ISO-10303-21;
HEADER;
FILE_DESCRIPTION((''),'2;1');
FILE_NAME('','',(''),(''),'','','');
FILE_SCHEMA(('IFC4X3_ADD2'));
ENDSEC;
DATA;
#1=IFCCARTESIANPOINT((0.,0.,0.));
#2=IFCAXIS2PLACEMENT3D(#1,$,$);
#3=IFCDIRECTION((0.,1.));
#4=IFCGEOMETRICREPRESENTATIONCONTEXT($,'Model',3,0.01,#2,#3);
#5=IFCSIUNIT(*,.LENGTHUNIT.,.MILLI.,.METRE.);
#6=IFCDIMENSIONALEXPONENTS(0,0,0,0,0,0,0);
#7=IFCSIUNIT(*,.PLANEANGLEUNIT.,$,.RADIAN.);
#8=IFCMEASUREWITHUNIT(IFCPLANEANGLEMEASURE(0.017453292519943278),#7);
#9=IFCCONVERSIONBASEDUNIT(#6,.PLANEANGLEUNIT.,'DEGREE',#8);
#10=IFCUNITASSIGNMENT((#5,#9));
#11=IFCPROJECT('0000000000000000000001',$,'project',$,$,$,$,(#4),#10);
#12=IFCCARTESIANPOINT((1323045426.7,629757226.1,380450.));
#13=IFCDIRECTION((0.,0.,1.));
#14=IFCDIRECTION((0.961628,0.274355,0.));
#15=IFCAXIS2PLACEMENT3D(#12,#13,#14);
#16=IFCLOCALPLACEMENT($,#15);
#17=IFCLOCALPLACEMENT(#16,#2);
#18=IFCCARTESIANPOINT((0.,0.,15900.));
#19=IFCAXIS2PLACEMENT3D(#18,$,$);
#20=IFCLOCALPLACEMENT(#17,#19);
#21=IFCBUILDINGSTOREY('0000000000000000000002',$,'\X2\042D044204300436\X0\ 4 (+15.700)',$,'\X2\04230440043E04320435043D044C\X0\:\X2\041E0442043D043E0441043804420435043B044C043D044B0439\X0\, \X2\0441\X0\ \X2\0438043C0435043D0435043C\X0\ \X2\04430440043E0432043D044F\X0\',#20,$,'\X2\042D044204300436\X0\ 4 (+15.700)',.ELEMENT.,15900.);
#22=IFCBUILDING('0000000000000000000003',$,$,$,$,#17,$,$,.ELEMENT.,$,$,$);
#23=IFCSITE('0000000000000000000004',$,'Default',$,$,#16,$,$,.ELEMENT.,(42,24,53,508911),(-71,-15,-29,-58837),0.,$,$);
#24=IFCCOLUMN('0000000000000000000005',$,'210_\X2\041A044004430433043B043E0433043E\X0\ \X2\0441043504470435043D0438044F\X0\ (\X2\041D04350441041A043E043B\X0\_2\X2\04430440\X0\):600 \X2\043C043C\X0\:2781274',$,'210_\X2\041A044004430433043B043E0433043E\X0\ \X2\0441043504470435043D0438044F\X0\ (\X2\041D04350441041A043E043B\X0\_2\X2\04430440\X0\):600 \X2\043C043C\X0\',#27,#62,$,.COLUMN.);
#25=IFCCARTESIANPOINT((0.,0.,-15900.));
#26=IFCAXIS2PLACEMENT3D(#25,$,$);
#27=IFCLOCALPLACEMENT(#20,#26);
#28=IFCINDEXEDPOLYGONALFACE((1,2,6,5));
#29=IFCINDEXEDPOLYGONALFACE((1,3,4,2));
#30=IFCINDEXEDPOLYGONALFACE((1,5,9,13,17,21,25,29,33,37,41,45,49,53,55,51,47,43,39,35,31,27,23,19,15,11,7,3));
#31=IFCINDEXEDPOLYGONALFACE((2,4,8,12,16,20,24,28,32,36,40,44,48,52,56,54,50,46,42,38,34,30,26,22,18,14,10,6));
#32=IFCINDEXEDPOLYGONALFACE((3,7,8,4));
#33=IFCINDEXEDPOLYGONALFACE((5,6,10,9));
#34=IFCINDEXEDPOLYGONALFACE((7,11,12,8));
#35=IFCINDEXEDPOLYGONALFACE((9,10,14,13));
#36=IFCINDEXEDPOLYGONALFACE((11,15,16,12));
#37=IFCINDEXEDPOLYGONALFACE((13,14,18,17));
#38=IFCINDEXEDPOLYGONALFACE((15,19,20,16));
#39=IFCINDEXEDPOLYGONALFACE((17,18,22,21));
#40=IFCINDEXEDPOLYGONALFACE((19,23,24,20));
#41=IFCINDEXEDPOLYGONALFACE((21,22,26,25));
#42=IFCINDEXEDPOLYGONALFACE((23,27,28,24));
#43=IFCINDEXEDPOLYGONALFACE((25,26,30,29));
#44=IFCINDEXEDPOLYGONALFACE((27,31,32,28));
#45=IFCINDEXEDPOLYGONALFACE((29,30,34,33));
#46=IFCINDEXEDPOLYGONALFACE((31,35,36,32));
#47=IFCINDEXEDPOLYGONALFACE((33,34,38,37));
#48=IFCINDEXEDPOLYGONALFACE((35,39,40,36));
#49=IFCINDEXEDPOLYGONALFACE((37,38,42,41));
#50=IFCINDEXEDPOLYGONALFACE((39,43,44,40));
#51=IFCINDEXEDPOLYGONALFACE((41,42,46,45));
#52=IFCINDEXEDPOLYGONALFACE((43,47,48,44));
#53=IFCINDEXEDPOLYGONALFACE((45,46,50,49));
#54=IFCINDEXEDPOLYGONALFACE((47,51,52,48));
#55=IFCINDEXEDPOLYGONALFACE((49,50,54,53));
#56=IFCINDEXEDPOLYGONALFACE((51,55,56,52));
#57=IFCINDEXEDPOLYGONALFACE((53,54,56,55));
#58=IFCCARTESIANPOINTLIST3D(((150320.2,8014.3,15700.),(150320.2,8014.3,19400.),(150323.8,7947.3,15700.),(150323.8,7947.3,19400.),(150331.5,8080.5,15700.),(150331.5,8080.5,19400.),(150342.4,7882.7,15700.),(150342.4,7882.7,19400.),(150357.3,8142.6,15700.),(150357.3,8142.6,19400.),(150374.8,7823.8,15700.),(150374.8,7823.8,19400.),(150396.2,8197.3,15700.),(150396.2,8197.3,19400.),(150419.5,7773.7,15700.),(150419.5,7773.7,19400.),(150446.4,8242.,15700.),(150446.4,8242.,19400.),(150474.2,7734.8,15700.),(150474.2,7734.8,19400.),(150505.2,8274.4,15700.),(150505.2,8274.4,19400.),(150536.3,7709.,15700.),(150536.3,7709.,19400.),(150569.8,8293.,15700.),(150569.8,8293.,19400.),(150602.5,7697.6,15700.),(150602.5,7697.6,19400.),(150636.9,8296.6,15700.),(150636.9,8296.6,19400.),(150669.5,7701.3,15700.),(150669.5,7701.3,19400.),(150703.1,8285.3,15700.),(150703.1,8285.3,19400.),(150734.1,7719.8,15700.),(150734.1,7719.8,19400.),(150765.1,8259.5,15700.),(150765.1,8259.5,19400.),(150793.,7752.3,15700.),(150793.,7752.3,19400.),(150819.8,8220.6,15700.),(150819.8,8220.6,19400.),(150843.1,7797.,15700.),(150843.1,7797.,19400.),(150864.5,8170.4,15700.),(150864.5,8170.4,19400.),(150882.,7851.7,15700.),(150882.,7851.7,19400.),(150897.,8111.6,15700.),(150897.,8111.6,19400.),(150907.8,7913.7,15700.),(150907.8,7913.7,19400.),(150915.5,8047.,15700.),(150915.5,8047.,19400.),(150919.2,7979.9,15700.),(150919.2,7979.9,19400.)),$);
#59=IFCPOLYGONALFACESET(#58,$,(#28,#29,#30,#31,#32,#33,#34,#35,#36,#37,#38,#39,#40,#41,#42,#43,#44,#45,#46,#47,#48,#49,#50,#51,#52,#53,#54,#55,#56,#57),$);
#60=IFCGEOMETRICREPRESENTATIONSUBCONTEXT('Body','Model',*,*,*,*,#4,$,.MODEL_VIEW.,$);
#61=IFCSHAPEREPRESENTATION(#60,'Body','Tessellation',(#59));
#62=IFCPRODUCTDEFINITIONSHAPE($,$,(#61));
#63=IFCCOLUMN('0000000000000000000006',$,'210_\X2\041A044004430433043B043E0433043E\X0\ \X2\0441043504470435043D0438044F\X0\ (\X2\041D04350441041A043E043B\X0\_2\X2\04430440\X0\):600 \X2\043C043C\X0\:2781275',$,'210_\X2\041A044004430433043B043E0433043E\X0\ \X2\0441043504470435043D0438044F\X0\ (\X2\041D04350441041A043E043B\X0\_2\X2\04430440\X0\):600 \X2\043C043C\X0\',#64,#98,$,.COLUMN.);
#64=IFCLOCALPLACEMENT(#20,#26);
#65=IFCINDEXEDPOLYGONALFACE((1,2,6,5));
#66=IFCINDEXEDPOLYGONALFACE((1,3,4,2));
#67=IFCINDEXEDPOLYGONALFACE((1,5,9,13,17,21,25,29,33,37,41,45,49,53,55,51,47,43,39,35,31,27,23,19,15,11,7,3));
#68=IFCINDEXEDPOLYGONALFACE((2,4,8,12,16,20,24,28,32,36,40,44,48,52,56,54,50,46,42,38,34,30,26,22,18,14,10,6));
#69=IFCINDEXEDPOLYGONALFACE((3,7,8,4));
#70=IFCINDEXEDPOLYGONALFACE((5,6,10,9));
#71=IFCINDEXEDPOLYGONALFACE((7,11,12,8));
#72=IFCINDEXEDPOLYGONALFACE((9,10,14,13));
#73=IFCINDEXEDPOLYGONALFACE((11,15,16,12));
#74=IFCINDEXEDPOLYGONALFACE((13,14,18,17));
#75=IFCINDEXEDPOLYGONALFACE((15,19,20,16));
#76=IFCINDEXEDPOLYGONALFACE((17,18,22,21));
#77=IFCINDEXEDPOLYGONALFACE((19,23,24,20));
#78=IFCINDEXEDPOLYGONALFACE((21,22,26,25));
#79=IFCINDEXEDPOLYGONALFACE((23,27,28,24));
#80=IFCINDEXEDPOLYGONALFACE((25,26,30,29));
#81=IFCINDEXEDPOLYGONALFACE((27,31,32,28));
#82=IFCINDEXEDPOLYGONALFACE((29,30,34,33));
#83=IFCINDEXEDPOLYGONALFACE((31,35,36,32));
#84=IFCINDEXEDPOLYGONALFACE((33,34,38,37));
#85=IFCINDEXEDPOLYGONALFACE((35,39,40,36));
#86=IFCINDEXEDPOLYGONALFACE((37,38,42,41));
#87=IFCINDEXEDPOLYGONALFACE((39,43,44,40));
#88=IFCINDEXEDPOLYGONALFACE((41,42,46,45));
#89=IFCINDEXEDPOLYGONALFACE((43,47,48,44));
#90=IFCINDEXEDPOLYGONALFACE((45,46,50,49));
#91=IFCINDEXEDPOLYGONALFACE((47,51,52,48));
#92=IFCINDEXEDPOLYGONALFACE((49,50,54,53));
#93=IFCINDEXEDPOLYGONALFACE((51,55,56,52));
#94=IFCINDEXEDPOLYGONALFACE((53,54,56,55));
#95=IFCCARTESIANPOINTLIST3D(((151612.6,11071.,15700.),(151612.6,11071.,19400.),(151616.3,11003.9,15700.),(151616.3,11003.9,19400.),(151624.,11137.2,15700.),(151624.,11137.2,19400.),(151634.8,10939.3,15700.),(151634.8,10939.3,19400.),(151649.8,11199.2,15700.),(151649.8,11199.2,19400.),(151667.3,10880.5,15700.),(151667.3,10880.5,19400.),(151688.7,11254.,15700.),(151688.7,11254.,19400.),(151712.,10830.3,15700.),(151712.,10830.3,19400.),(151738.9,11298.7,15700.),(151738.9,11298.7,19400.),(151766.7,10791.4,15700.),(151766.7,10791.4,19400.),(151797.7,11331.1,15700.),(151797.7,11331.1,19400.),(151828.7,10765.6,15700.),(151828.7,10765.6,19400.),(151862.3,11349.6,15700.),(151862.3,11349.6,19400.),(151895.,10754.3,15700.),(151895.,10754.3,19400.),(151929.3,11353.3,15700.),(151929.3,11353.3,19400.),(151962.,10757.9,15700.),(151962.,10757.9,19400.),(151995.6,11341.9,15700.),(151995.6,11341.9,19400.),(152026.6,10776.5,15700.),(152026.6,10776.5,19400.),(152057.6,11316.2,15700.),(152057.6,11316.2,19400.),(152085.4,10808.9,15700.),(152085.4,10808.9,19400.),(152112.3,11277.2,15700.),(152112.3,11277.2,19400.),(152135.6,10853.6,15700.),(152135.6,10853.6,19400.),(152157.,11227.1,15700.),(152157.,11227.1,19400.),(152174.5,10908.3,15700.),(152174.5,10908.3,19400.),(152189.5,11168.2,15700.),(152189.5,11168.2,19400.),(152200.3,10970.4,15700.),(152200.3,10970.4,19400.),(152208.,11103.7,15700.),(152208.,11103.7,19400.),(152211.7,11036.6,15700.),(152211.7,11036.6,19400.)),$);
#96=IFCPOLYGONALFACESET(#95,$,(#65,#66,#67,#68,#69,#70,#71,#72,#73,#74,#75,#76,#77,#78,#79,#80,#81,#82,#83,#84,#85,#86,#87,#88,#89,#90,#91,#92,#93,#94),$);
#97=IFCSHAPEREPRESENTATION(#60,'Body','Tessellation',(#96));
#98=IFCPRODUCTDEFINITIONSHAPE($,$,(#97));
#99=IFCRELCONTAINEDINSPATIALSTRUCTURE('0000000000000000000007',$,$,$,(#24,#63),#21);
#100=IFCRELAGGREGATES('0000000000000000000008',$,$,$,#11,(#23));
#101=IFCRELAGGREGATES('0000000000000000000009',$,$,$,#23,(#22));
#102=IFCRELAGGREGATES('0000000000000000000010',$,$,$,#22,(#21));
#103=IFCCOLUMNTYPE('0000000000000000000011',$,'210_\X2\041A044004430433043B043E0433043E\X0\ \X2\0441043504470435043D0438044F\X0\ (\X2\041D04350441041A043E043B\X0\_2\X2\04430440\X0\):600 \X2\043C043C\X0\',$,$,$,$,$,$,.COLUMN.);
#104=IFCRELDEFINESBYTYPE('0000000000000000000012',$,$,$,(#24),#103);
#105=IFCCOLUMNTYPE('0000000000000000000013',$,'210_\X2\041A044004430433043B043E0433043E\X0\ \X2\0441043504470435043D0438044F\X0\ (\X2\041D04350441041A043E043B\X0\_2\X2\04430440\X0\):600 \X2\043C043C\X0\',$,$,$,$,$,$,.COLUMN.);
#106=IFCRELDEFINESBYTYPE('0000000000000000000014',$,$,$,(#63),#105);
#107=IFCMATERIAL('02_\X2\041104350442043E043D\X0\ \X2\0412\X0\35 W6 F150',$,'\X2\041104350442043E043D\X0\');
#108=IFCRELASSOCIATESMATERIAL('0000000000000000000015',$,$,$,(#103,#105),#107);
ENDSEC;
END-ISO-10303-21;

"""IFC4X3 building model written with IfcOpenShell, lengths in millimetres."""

from ifc_helpers import new_model, entity, si_unit, converted_unit, direction, frame, frame_2d, origin, place, context, subcontext, project, spatial, circle, extrude, source, transform, mapped, material, material_profile, profile_set, type_object, type_shapes, element, save


model = new_model("IFC4X3")

# Units and contexts
model_context = context("Model", 3, precision=0.01, world=origin(), true_north=direction((0.0, 1.0)))
body_context = subcontext(model_context, "Body", "Model", "MODEL_VIEW")
ifc_project = project(units=[si_unit("LENGTHUNIT", "METRE", prefix="MILLI"), converted_unit("PLANEANGLEUNIT", "DEGREE", entity("IfcPlaneAngleMeasure", 0.017453292519943278), si_unit("PLANEANGLEUNIT", "RADIAN"), dimensions=[0, 0, 0, 0, 0, 0, 0])], contexts=[model_context])

# Site, building, storey
site_placement = place(None, frame((1323045426.7, 629757226.1, 380450.0), z_axis=(0.0, 0.0, 1.0), x_axis=(0.961628, 0.274355, 0.0)))
site = spatial("IfcSite", under=ifc_project, at=site_placement, Name="Default", CompositionType="ELEMENT", RefLatitude=(42, 24, 53, 508911), RefLongitude=(-71, -15, -29, -58837), RefElevation=0.0)
building_placement = place(site_placement, origin())
building = spatial("IfcBuilding", under=site, at=building_placement, CompositionType="ELEMENT")
storey_placement = place(building_placement, frame((0.0, 0.0, 15900.0)))
storey = spatial("IfcBuildingStorey", under=building, at=storey_placement, Name="Этаж 4 (+15.700)", ObjectType="Уровень:Относительный, с именем уровня", LongName="Этаж 4 (+15.700)", CompositionType="ELEMENT", Elevation=15900.0)

# Columns
ifc_material = material(Name="02_Бетон В35 W6 F150", Category="Бетон")
ifc_material_profile_1 = material_profile(ifc_material, circle(Radius=300.0, at=frame_2d((0.0, 0.0), x_axis=(1.0, 0.0))), Name="600 мм")
ifc_profile_set_1 = profile_set([ifc_material_profile_1], Name="600 мм")
column_type_1 = type_object("IfcColumnType", Name="210_Круглого сечения (НесКол_2ур):600 мм", PredefinedType="COLUMN", material=ifc_profile_set_1)
shared_shape_1 = source(origin(), body_context, "Body", "SweptSolid", [
    extrude(circle(Radius=300.0, at=frame_2d((0.0, 0.0), x_axis=(1.0, 0.0))), frame((150619.7, 7997.1, 15700.0), z_axis=(0.0, 0.0, 1.0), x_axis=(0.87462, -0.48481, 0.0)), (0.0, 0.0, 1.0), 3700.0),
])
type_shapes(column_type_1, [shared_shape_1])
column_1_placement = place(storey_placement, frame((0.0, 0.0, -15900.0)))
element("IfcColumn", 1, at=column_1_placement, inside=storey, type_object=column_type_1, Name="210_Круглого сечения (НесКол_2ур):600 мм:2781274", ObjectType="210_Круглого сечения (НесКол_2ур):600 мм", PredefinedType="COLUMN", context=body_context, shape_type="MappedRepresentation", body=[
    mapped(shared_shape_1, transform((0.0, 0.0, 0.0), scale=1.0)),
])
column_type_2 = type_object("IfcColumnType", Name="210_Круглого сечения (НесКол_2ур):600 мм", PredefinedType="COLUMN", material=ifc_profile_set_1)
shared_shape_2 = source(origin(), body_context, "Body", "SweptSolid", [
    extrude(circle(Radius=300.0, at=frame_2d((0.0, 0.0), x_axis=(1.0, 0.0))), frame((151912.1, 11053.8, 15700.0), z_axis=(0.0, 0.0, 1.0), x_axis=(0.87462, -0.48481, 0.0)), (0.0, 0.0, 1.0), 3700.0),
])
type_shapes(column_type_2, [shared_shape_2])
column_2_placement = place(storey_placement, frame((0.0, 0.0, -15900.0)))
element("IfcColumn", 2, at=column_2_placement, inside=storey, type_object=column_type_2, Name="210_Круглого сечения (НесКол_2ур):600 мм:2781275", ObjectType="210_Круглого сечения (НесКол_2ур):600 мм", PredefinedType="COLUMN", context=body_context, shape_type="MappedRepresentation", body=[
    mapped(shared_shape_2, transform((0.0, 0.0, 0.0), scale=1.0)),
])

save(model, "model.ifc")
